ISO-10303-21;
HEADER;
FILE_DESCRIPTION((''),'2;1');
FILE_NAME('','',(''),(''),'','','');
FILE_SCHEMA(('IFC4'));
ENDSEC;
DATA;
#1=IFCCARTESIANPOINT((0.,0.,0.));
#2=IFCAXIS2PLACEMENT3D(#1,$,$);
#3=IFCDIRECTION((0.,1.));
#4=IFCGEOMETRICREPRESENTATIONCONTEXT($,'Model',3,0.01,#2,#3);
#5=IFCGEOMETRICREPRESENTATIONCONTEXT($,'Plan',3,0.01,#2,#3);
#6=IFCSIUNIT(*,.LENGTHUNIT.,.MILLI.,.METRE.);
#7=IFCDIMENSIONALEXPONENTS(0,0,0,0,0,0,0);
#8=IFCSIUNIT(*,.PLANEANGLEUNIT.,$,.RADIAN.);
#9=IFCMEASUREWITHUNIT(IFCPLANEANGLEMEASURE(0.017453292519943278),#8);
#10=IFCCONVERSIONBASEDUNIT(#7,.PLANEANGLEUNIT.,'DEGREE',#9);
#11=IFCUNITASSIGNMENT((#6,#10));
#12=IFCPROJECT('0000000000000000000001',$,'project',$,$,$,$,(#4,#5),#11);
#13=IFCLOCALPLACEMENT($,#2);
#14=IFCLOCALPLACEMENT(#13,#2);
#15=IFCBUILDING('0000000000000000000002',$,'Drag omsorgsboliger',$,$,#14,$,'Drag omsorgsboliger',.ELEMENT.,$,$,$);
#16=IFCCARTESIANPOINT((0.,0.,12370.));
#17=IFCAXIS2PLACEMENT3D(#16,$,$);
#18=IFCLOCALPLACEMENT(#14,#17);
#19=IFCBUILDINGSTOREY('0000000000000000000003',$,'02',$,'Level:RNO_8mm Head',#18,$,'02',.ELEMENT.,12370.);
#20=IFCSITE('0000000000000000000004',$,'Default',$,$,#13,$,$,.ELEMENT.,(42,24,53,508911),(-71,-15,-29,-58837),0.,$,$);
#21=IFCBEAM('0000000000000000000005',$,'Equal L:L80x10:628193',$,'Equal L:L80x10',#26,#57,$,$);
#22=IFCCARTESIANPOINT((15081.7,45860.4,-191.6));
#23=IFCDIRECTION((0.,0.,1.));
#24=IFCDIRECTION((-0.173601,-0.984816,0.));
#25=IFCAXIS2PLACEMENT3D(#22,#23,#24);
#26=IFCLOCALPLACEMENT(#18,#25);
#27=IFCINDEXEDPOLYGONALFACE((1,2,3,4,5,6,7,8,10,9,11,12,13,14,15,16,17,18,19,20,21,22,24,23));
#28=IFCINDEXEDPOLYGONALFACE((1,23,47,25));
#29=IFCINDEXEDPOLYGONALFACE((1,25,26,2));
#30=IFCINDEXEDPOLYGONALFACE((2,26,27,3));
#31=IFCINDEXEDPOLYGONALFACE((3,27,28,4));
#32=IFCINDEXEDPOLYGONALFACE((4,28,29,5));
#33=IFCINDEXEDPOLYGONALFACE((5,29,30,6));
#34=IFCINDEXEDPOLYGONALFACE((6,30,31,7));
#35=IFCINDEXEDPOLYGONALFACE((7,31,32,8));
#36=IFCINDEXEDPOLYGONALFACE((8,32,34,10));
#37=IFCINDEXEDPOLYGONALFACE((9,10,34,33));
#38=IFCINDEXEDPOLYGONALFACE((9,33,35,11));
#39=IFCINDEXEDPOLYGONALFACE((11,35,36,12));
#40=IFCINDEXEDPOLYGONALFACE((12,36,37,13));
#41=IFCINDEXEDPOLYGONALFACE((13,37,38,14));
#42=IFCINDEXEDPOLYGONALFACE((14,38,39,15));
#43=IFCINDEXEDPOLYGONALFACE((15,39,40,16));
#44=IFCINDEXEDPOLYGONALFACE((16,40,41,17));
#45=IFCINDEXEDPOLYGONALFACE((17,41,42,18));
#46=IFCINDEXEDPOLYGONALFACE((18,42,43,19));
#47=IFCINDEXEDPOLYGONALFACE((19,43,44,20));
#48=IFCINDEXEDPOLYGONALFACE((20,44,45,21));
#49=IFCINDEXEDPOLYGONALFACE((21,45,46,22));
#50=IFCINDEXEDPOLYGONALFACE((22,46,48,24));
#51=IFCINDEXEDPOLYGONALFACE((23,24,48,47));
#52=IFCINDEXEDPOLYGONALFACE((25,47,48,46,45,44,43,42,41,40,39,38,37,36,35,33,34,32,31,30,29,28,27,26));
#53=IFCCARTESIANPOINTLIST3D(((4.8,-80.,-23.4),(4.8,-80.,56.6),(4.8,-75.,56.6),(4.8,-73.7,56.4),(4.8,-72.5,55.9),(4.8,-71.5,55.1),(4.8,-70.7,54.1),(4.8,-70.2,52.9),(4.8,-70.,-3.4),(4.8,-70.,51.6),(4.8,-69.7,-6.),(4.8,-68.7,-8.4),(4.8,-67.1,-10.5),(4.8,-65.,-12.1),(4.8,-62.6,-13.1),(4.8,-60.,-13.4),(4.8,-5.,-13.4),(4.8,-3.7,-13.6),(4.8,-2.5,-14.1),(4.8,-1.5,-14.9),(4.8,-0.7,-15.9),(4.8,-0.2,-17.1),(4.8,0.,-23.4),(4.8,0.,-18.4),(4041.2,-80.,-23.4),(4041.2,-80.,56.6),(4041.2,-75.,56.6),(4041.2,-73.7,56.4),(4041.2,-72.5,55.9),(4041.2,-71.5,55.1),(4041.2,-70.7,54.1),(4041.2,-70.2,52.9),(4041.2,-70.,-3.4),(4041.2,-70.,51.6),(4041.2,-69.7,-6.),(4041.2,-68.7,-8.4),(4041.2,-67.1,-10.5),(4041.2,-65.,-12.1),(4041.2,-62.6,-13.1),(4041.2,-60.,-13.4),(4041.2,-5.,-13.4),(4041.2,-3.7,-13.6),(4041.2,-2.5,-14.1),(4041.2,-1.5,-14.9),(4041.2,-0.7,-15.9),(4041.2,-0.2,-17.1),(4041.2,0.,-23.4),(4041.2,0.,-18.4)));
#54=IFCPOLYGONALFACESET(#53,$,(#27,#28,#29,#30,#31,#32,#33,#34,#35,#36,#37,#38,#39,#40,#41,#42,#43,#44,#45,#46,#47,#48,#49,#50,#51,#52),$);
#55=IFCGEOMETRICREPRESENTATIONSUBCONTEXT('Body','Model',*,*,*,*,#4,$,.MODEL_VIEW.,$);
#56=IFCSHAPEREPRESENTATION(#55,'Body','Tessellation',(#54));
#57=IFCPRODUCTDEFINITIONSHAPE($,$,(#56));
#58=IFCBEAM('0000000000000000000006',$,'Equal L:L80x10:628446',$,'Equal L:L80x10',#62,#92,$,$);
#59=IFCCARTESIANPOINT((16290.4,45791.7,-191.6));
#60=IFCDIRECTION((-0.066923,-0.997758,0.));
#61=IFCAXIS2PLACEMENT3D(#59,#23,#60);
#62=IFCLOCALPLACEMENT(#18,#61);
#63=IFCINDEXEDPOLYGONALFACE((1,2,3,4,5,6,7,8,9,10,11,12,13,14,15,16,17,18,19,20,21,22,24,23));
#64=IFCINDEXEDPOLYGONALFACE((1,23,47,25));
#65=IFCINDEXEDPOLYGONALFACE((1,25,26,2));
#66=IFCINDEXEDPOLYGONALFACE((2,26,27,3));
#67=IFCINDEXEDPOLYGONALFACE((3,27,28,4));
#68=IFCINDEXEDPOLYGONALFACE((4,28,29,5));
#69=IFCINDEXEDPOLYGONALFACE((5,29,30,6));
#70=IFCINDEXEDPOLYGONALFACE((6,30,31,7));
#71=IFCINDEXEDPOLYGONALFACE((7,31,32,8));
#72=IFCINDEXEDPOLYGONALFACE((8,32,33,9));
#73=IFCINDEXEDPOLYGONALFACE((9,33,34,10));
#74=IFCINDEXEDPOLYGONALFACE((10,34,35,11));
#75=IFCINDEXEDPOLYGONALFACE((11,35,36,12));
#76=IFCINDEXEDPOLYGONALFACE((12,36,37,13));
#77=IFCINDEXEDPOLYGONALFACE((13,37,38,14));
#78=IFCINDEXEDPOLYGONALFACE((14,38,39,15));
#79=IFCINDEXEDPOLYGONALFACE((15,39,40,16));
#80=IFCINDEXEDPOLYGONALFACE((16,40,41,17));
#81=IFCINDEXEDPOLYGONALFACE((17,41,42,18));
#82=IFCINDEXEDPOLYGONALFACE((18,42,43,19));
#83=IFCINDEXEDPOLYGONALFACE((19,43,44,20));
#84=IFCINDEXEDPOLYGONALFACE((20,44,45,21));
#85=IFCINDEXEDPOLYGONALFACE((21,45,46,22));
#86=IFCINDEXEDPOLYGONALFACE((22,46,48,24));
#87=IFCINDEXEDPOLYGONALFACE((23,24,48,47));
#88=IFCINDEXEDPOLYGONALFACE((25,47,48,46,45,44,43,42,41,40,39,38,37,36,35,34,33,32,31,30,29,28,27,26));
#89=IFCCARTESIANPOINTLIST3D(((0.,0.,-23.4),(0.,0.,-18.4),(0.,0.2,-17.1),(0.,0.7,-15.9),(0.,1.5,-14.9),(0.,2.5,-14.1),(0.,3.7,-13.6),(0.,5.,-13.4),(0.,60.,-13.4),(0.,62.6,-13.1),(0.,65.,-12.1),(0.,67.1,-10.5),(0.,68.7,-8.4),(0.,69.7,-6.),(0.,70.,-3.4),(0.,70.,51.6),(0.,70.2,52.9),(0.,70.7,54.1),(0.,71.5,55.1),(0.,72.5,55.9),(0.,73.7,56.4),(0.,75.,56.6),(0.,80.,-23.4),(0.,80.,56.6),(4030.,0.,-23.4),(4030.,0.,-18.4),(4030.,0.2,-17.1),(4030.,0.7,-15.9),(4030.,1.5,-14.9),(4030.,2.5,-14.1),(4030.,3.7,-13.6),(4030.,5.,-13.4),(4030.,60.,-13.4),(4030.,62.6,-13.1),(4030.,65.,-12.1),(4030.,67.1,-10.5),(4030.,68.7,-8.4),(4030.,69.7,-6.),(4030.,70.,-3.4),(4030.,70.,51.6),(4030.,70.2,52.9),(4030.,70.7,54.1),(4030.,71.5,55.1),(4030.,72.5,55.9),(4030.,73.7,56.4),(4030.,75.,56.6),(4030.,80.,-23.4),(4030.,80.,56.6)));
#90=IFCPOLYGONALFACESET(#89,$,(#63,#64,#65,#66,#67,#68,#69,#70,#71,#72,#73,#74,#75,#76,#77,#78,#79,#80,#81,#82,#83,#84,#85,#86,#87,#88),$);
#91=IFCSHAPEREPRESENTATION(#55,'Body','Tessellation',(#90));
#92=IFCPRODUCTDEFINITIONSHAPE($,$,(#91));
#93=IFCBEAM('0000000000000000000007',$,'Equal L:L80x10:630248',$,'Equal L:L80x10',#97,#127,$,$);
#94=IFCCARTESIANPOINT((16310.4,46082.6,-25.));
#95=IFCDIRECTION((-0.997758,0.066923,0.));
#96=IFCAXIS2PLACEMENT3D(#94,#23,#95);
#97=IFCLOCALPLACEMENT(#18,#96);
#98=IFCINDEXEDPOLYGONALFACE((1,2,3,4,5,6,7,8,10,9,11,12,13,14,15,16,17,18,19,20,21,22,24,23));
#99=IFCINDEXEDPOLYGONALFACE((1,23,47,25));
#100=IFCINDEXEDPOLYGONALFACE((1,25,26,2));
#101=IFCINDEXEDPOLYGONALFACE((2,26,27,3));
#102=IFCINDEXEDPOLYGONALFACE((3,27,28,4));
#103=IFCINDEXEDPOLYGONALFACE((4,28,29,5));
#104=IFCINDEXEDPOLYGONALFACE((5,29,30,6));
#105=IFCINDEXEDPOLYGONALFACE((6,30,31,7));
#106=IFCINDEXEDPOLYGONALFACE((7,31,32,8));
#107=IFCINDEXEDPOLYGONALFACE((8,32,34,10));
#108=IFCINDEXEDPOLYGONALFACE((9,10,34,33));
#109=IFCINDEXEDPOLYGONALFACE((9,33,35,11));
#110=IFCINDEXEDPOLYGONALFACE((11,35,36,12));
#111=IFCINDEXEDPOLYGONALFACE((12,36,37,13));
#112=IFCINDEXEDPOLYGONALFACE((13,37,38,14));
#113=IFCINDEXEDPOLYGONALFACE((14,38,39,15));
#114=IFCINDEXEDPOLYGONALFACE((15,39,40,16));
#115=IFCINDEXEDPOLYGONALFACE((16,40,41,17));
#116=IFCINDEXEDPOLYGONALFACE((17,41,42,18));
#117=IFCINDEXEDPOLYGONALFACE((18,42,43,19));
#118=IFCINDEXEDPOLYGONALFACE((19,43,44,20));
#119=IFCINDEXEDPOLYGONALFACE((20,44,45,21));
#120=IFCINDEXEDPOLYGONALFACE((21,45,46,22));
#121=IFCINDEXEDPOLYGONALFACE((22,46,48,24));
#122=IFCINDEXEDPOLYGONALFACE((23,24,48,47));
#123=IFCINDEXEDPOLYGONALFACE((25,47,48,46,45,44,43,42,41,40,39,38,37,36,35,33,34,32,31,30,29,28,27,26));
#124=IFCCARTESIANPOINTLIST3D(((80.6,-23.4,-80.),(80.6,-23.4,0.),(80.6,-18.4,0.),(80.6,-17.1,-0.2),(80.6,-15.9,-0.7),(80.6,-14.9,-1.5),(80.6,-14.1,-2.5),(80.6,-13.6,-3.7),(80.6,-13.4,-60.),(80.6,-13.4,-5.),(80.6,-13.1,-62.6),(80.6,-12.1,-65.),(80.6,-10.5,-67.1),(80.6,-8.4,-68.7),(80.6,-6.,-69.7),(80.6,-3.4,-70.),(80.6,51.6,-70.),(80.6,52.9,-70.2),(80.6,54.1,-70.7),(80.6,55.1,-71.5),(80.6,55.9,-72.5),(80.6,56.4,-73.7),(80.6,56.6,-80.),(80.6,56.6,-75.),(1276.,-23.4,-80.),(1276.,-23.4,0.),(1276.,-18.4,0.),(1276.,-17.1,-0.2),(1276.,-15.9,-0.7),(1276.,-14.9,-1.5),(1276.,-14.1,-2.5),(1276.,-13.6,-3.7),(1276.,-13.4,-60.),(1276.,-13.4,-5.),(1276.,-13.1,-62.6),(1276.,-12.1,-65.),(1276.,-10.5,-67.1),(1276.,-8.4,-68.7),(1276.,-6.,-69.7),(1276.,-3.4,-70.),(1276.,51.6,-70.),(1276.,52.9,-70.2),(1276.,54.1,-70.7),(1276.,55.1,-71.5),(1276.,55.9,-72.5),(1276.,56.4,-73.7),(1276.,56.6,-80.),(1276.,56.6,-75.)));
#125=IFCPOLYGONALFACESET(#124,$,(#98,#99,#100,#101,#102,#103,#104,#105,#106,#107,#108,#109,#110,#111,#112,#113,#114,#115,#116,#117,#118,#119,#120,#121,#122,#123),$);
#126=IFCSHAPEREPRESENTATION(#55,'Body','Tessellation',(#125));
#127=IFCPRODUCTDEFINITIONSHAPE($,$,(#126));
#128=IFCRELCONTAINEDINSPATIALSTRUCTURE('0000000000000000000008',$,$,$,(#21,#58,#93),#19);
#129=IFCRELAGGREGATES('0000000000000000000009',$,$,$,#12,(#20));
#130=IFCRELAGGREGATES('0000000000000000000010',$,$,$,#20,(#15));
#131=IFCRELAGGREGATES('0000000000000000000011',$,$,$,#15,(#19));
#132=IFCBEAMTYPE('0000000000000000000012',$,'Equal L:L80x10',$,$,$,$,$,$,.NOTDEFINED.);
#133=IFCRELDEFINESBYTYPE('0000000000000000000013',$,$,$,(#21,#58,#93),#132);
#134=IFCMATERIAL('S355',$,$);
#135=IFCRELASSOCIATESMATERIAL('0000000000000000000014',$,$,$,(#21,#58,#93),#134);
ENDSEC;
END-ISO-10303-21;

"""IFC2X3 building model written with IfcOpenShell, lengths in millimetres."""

from ifc_helpers import new_model, entity, si_unit, converted_unit, direction, frame, frame_2d, origin, place, context, subcontext, project, spatial, polyline, circle_curve, parameter, trimmed, segment, composite_curve, outline, extrude, material, type_object, element, save


model = new_model("IFC2X3")

# Units and contexts
model_context = context("Model", 3, precision=0.01, world=origin(), true_north=direction((0.0, 1.0)))
plan_context = context("Plan", 3, precision=0.01, world=origin(), true_north=direction((0.0, 1.0)))
body_context = subcontext(model_context, "Body", "Model", "MODEL_VIEW")
ifc_project = project(units=[si_unit("LENGTHUNIT", "METRE", prefix="MILLI"), converted_unit("PLANEANGLEUNIT", "DEGREE", entity("IfcPlaneAngleMeasure", 0.017453292519943278), si_unit("PLANEANGLEUNIT", "RADIAN"), dimensions=[0, 0, 0, 0, 0, 0, 0])], contexts=[model_context, plan_context])

# Site, building, storey
site_placement = place(None, origin())
site = spatial("IfcSite", under=ifc_project, at=site_placement, Name="Default", CompositionType="ELEMENT", RefLatitude=(42, 24, 53, 508911), RefLongitude=(-71, -15, -29, -58837), RefElevation=0.0)
building_placement = place(site_placement, origin())
building = spatial("IfcBuilding", under=site, at=building_placement, Name="Drag omsorgsboliger", LongName="Drag omsorgsboliger", CompositionType="ELEMENT")
storey_placement = place(building_placement, frame((0.0, 0.0, 12370.0)))
storey = spatial("IfcBuildingStorey", under=building, at=storey_placement, Name="02", ObjectType="Level:RNO_8mm Head", LongName="02", CompositionType="ELEMENT", Elevation=12370.0)

# Beams
ifc_material_1 = material(Name="S355")
beam_type_1 = type_object("IfcBeamType", Name="Equal L:L80x10", PredefinedType="NOTDEFINED")
beam_1_placement = place(storey_placement, frame((15081.7, 45860.4, -191.6), z_axis=(0.0, 0.0, 1.0), x_axis=(-0.173601, -0.984816, 0.0)))
element("IfcBeam", 1, at=beam_1_placement, inside=storey, type_object=beam_type_1, material=ifc_material_1, Name="Equal L:L80x10:628193", ObjectType="Equal L:L80x10", context=body_context, shape_type="SweptSolid", body=[
    extrude(outline(composite_curve([segment(polyline([(-48.9, -31.1), (31.1, -31.1)]), True, "CONTINUOUS"), segment(polyline([(31.1, -31.1), (31.1, 48.9)]), True, "CONTINUOUS"), segment(polyline([(31.1, 48.9), (26.1, 48.9)]), True, "CONTINUOUS"), segment(trimmed(circle_curve(frame_2d((26.1, 43.9), x_axis=(0.0, 1.0)), 5.0), [parameter(0.0)], [parameter(90.0)], True, "PARAMETER"), True, "CONTINUOUS"), segment(polyline([(21.1, 43.9), (21.1, -11.1)]), True, "CONTINUOUS"), segment(trimmed(circle_curve(frame_2d((11.1, -11.1), x_axis=(1.0, 0.0)), 10.0), [parameter(270.0)], [parameter(0.0)], True, "PARAMETER"), False, "CONTINUOUS"), segment(polyline([(11.1, -21.1), (-43.9, -21.1)]), True, "CONTINUOUS"), segment(trimmed(circle_curve(frame_2d((-43.9, -26.1), x_axis=(0.0, 1.0)), 5.0), [parameter(0.0)], [parameter(90.0)], True, "PARAMETER"), True, "CONTINUOUS"), segment(polyline([(-48.9, -26.1), (-48.9, -31.1)]), True, "CONTINUOUS")], self_intersect=False)), frame((4.8, -48.9, 7.7), z_axis=(1.0, 0.0, 0.0), x_axis=(0.0, 0.0, -1.0)), (0.0, 0.0, 1.0), 4036.4),
])
beam_2_placement = place(storey_placement, frame((16290.4, 45791.7, -191.6), z_axis=(0.0, 0.0, 1.0), x_axis=(-0.066923, -0.997758, 0.0)))
element("IfcBeam", 2, at=beam_2_placement, inside=storey, type_object=beam_type_1, material=ifc_material_1, Name="Equal L:L80x10:628446", ObjectType="Equal L:L80x10", context=body_context, shape_type="SweptSolid", body=[
    extrude(outline(composite_curve([segment(polyline([(26.1, -48.9), (31.1, -48.9)]), True, "CONTINUOUS"), segment(polyline([(31.1, -48.9), (31.1, 31.1)]), True, "CONTINUOUS"), segment(polyline([(31.1, 31.1), (-48.9, 31.1)]), True, "CONTINUOUS"), segment(polyline([(-48.9, 31.1), (-48.9, 26.1)]), True, "CONTINUOUS"), segment(trimmed(circle_curve(frame_2d((-43.9, 26.1), x_axis=(-1.0, 0.0)), 5.0), [parameter(0.0)], [parameter(90.0)], True, "PARAMETER"), True, "CONTINUOUS"), segment(polyline([(-43.9, 21.1), (11.1, 21.1)]), True, "CONTINUOUS"), segment(trimmed(circle_curve(frame_2d((11.1, 11.1), x_axis=(0.0, 1.0)), 10.0), [parameter(270.0)], [parameter(0.0)], True, "PARAMETER"), False, "CONTINUOUS"), segment(polyline([(21.1, 11.1), (21.1, -43.9)]), True, "CONTINUOUS"), segment(trimmed(circle_curve(frame_2d((26.1, -43.9), x_axis=(-1.0, 0.0)), 5.0), [parameter(0.0)], [parameter(90.0)], True, "PARAMETER"), True, "CONTINUOUS")], self_intersect=False)), frame((0.0, 48.9, 7.7), z_axis=(1.0, 0.0, 0.0), x_axis=(0.0, 0.0, -1.0)), (0.0, 0.0, 1.0), 4030.0),
])
beam_3_placement = place(storey_placement, frame((16310.4, 46082.6, -25.0), z_axis=(0.0, 0.0, 1.0), x_axis=(-0.997758, 0.066923, 0.0)))
element("IfcBeam", 3, at=beam_3_placement, inside=storey, type_object=beam_type_1, material=ifc_material_1, Name="Equal L:L80x10:630248", ObjectType="Equal L:L80x10", context=body_context, shape_type="SweptSolid", body=[
    extrude(outline(composite_curve([segment(polyline([(-48.9, -31.1), (31.1, -31.1)]), True, "CONTINUOUS"), segment(polyline([(31.1, -31.1), (31.1, 48.9)]), True, "CONTINUOUS"), segment(polyline([(31.1, 48.9), (26.1, 48.9)]), True, "CONTINUOUS"), segment(trimmed(circle_curve(frame_2d((26.1, 43.9), x_axis=(0.0, 1.0)), 5.0), [parameter(0.0)], [parameter(90.0)], True, "PARAMETER"), True, "CONTINUOUS"), segment(polyline([(21.1, 43.9), (21.1, -11.1)]), True, "CONTINUOUS"), segment(trimmed(circle_curve(frame_2d((11.1, -11.1), x_axis=(1.0, 0.0)), 10.0), [parameter(270.0)], [parameter(0.0)], True, "PARAMETER"), False, "CONTINUOUS"), segment(polyline([(11.1, -21.1), (-43.9, -21.1)]), True, "CONTINUOUS"), segment(trimmed(circle_curve(frame_2d((-43.9, -26.1), x_axis=(0.0, 1.0)), 5.0), [parameter(0.0)], [parameter(90.0)], True, "PARAMETER"), True, "CONTINUOUS"), segment(polyline([(-48.9, -26.1), (-48.9, -31.1)]), True, "CONTINUOUS")], self_intersect=False)), frame((80.6, 7.7, -48.9), z_axis=(1.0, 0.0, 0.0), x_axis=(0.0, 0.0, -1.0)), (0.0, 0.0, 1.0), 1195.4),
])

save(model, "model.ifc")
